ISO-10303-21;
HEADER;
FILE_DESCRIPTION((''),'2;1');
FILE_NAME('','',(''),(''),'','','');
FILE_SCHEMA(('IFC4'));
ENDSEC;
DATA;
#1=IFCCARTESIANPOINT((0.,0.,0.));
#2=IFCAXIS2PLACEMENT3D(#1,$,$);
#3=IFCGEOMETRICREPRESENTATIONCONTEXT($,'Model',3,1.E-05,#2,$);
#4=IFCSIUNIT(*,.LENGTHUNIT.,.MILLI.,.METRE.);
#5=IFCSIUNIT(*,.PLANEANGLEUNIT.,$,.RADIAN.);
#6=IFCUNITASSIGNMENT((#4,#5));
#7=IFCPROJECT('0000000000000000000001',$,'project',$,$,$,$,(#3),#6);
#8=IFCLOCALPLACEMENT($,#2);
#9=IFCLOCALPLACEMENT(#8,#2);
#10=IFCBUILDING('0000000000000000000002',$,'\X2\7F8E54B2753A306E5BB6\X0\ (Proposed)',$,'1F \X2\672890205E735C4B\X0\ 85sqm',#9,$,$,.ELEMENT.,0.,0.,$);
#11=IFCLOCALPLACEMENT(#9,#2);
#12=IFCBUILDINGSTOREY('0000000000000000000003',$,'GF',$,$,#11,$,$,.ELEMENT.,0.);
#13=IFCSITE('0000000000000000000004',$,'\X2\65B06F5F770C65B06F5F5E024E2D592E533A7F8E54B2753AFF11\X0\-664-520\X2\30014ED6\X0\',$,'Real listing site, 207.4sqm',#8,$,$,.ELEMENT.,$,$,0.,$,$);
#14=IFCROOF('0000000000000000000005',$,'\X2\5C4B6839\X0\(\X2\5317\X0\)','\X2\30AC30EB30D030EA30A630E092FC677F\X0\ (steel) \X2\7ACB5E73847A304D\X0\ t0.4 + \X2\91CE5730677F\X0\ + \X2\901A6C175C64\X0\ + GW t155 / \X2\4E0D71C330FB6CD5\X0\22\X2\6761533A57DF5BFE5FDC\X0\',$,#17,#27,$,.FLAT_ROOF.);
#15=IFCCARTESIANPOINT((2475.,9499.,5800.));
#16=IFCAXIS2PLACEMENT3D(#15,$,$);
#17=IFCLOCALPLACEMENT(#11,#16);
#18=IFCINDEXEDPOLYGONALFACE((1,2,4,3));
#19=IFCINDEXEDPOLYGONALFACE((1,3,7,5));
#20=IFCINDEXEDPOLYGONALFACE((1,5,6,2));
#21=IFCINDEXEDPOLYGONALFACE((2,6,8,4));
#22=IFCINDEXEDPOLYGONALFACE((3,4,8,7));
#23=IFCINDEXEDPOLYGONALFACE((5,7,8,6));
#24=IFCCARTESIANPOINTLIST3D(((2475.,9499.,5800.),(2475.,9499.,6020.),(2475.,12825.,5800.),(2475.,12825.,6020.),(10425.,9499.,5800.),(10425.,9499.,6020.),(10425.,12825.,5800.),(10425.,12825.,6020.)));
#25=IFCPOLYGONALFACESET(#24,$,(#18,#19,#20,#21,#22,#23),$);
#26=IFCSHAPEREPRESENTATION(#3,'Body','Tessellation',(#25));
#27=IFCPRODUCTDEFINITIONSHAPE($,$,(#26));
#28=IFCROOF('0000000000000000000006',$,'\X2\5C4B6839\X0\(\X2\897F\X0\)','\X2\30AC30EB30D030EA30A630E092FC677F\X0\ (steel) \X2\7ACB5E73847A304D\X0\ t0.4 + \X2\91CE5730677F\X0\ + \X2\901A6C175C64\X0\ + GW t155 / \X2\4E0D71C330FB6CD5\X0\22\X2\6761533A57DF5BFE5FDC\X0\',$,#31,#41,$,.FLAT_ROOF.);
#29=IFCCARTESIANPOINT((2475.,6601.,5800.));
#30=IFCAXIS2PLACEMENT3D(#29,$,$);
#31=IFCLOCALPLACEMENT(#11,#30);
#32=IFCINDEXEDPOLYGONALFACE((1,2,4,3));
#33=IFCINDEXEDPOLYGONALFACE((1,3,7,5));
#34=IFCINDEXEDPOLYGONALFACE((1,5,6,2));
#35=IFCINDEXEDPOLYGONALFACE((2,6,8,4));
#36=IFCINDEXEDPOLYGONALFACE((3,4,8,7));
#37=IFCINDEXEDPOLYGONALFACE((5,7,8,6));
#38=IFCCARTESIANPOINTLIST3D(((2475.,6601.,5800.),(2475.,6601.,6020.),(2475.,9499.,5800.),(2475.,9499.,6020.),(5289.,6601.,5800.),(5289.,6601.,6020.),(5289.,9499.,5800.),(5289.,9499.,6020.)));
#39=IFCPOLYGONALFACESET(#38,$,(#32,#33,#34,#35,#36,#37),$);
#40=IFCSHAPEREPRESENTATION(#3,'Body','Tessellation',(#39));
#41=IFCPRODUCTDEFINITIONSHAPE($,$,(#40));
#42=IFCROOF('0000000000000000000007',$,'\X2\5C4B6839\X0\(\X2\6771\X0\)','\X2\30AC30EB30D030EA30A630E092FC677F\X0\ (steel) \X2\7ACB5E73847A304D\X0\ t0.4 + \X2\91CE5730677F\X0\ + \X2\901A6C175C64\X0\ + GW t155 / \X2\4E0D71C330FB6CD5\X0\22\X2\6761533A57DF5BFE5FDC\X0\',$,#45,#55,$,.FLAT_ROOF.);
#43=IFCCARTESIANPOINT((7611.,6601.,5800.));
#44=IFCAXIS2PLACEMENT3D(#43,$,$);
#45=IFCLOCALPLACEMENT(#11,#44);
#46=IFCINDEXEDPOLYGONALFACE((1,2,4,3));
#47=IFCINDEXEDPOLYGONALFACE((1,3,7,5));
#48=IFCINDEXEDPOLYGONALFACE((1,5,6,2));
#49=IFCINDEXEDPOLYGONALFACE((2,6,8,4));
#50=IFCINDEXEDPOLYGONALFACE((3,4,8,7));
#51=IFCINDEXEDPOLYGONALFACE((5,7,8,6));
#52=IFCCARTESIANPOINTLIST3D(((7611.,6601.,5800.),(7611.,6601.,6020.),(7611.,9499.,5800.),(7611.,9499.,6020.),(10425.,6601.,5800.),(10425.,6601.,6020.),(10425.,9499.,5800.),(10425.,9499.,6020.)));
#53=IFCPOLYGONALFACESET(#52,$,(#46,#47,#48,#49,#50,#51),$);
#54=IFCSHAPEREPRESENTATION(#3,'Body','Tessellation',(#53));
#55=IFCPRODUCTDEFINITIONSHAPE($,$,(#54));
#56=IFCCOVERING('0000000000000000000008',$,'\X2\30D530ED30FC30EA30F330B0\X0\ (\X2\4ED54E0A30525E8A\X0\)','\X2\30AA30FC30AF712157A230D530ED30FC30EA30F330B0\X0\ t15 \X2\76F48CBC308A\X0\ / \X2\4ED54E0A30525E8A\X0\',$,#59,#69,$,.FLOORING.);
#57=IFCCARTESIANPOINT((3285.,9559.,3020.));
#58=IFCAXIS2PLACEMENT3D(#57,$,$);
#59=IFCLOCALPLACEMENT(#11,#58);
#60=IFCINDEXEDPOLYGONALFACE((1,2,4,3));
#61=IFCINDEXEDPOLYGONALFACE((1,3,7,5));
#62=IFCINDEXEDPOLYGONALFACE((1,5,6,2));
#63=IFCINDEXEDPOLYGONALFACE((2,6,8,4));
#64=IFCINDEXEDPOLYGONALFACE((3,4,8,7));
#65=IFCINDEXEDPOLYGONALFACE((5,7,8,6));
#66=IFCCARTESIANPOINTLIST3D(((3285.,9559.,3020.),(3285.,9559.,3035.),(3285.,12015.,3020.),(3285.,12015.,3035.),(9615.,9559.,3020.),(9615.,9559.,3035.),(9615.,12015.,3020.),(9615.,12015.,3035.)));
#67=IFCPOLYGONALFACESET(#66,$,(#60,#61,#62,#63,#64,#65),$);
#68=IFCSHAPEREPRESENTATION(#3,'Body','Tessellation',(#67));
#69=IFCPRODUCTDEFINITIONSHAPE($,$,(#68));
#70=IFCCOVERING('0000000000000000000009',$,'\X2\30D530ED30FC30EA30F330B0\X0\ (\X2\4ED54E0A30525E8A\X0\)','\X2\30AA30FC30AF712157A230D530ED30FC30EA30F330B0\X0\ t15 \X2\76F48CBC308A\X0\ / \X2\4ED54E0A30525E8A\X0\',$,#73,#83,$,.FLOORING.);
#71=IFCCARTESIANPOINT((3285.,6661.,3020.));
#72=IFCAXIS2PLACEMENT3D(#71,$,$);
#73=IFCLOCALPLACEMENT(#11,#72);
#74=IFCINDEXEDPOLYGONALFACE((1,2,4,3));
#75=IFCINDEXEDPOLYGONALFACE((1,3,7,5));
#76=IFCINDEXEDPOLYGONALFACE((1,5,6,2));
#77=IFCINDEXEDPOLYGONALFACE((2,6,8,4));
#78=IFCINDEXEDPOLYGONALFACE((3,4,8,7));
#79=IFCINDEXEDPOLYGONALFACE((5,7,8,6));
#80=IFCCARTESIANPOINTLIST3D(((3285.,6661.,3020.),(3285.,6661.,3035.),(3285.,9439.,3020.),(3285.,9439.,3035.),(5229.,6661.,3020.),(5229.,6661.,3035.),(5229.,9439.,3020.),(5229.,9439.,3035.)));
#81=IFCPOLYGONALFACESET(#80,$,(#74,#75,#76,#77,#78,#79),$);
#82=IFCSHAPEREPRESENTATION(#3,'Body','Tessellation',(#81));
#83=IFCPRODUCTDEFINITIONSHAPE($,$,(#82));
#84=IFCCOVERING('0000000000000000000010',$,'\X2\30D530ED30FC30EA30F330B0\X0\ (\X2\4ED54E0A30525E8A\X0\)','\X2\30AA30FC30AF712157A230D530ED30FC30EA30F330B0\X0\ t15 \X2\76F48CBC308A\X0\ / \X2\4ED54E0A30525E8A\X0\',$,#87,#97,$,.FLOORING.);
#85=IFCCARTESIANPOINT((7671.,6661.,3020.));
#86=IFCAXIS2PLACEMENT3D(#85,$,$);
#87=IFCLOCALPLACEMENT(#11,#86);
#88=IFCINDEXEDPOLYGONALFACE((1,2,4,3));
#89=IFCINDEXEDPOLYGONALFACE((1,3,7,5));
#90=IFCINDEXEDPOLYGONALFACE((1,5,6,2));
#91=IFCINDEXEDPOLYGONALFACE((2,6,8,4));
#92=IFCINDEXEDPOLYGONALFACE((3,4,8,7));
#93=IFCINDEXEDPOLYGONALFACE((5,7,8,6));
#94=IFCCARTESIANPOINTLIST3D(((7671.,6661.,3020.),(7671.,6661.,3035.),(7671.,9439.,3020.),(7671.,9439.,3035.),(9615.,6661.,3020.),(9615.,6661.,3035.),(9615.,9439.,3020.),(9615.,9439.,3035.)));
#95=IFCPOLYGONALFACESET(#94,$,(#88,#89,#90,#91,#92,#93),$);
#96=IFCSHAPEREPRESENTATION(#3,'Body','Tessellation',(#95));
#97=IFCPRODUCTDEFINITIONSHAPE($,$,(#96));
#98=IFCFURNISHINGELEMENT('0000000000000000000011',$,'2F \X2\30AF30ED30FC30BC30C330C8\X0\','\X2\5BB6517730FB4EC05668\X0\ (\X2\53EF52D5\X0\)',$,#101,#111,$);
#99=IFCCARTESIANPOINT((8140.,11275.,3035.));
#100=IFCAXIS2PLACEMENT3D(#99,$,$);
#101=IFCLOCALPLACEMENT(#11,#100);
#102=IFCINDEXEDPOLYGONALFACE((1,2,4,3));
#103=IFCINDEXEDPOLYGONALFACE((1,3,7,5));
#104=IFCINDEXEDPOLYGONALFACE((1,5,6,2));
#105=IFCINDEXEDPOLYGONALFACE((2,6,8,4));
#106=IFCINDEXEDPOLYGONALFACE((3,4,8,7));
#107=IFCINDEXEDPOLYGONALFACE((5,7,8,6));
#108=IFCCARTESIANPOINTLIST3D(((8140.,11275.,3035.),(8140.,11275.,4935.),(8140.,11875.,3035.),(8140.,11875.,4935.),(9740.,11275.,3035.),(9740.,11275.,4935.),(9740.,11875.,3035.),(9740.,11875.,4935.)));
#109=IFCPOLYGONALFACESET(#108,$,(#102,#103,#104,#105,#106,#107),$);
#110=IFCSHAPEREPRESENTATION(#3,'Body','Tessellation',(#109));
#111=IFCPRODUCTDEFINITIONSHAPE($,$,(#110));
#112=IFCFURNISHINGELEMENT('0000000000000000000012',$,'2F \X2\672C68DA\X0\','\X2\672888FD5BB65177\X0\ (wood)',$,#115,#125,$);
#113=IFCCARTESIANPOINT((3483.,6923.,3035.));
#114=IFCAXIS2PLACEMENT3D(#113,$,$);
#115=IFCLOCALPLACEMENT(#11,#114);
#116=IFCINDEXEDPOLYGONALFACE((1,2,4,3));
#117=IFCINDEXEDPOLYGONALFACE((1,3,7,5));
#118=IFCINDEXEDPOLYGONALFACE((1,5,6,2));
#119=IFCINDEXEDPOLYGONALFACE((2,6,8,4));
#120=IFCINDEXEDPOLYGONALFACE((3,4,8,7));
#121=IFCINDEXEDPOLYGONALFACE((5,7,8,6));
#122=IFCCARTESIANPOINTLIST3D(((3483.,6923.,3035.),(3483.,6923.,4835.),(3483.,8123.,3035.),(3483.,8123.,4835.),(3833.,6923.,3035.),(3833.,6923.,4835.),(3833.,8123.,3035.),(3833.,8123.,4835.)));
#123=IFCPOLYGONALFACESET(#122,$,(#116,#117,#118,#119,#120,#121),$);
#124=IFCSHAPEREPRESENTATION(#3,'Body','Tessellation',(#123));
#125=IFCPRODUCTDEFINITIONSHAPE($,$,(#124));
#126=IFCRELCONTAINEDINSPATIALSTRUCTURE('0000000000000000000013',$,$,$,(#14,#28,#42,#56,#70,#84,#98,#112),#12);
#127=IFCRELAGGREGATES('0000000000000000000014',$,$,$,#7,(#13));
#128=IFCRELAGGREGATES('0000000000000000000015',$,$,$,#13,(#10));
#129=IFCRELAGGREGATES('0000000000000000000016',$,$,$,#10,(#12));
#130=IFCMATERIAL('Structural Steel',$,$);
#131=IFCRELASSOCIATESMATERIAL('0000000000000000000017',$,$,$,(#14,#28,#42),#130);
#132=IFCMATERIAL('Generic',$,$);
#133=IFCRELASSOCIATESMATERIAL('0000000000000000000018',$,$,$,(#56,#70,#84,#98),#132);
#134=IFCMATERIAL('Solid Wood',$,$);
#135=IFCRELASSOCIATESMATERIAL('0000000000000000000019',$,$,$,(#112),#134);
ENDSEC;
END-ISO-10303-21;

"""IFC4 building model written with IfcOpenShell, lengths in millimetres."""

from ifc_helpers import new_model, si_unit, frame, frame_2d, origin, place, context, project, spatial, rectangle, extrude, material, element, save


model = new_model("IFC4")

# Units and contexts
model_context = context("Model", 3, precision=1e-05, world=origin())
ifc_project = project(units=[si_unit("LENGTHUNIT", "METRE", prefix="MILLI"), si_unit("PLANEANGLEUNIT", "RADIAN")], contexts=[model_context])

# Site, building, storey
site_placement = place(None, origin())
site = spatial("IfcSite", under=ifc_project, at=site_placement, Name="新潟県新潟市中央区美咲町１-664-520、他", ObjectType="Real listing site, 207.4sqm", CompositionType="ELEMENT", RefElevation=0.0)
building_placement = place(site_placement, origin())
building = spatial("IfcBuilding", under=site, at=building_placement, Name="美咲町の家 (Proposed)", ObjectType="1F 木造平屋 85sqm", CompositionType="ELEMENT", ElevationOfRefHeight=0.0, ElevationOfTerrain=0.0)
storey_placement = place(building_placement, origin())
storey = spatial("IfcBuildingStorey", under=building, at=storey_placement, Name="GF", CompositionType="ELEMENT", Elevation=0.0)

# Shared definitions
ifc_material_1 = material(Name="Solid Wood")

# Shared definitions
ifc_material_2 = material(Name="Generic")

# Roofs
ifc_material_3 = material(Name="Structural Steel")
for number, where, name in (
    (1, (2475.0, 9499.0, 5800.0), "屋根(北)"),
):
    element("IfcRoof", number, at=place(storey_placement, frame(where)), inside=storey, material=ifc_material_3, Name=name, Description="ガルバリウム鋼板 (steel) 立平葺き t0.4 + 野地板 + 通気層 + GW t155 / 不燃・法22条区域対応", PredefinedType="FLAT_ROOF", context=model_context, shape_type="SweptSolid", body=[
        extrude(rectangle(XDim=7950.0, YDim=3326.0, at=frame_2d((3975.0, 1663.0))), frame((2475.0, 9499.0, 5800.0)), (0.0, 0.0, 1.0), 220.0),
    ])
roof_1_placement = place(storey_placement, frame((2475.0, 6601.0, 5800.0)))
element("IfcRoof", 2, at=roof_1_placement, inside=storey, material=ifc_material_3, Name="屋根(西)", Description="ガルバリウム鋼板 (steel) 立平葺き t0.4 + 野地板 + 通気層 + GW t155 / 不燃・法22条区域対応", PredefinedType="FLAT_ROOF", context=model_context, shape_type="SweptSolid", body=[
    extrude(rectangle(XDim=2814.0, YDim=2898.0, at=frame_2d((1407.0, 1449.0))), frame((2475.0, 6601.0, 5800.0)), (0.0, 0.0, 1.0), 220.0),
])
roof_2_placement = place(storey_placement, frame((7611.0, 6601.0, 5800.0)))
element("IfcRoof", 3, at=roof_2_placement, inside=storey, material=ifc_material_3, Name="屋根(東)", Description="ガルバリウム鋼板 (steel) 立平葺き t0.4 + 野地板 + 通気層 + GW t155 / 不燃・法22条区域対応", PredefinedType="FLAT_ROOF", context=model_context, shape_type="SweptSolid", body=[
    extrude(rectangle(XDim=2814.0, YDim=2898.0, at=frame_2d((1407.0, 1449.0))), frame((7611.0, 6601.0, 5800.0)), (0.0, 0.0, 1.0), 220.0),
])

# Coverings
covering_1_placement = place(storey_placement, frame((3285.0, 9559.0, 3020.0)))
element("IfcCovering", 4, at=covering_1_placement, inside=storey, material=ifc_material_2, Name="フローリング (仕上げ床)", Description="オーク無垢フローリング t15 直貼り / 仕上げ床", PredefinedType="FLOORING", context=model_context, shape_type="SweptSolid", body=[
    extrude(rectangle(XDim=6330.0, YDim=2456.0, at=frame_2d((3165.0, 1228.0))), frame((3285.0, 9559.0, 3020.0)), (0.0, 0.0, 1.0), 15.0),
])
covering_2_placement = place(storey_placement, frame((3285.0, 6661.0, 3020.0)))
element("IfcCovering", 5, at=covering_2_placement, inside=storey, material=ifc_material_2, Name="フローリング (仕上げ床)", Description="オーク無垢フローリング t15 直貼り / 仕上げ床", PredefinedType="FLOORING", context=model_context, shape_type="SweptSolid", body=[
    extrude(rectangle(XDim=1944.0, YDim=2778.0, at=frame_2d((972.0, 1389.0))), frame((3285.0, 6661.0, 3020.0)), (0.0, 0.0, 1.0), 15.0),
])
covering_3_placement = place(storey_placement, frame((7671.0, 6661.0, 3020.0)))
element("IfcCovering", 6, at=covering_3_placement, inside=storey, material=ifc_material_2, Name="フローリング (仕上げ床)", Description="オーク無垢フローリング t15 直貼り / 仕上げ床", PredefinedType="FLOORING", context=model_context, shape_type="SweptSolid", body=[
    extrude(rectangle(XDim=1944.0, YDim=2778.0, at=frame_2d((972.0, 1389.0))), frame((7671.0, 6661.0, 3020.0)), (0.0, 0.0, 1.0), 15.0),
])

# Furnishing elements
furnishing_1_placement = place(storey_placement, frame((8140.0, 11275.0, 3035.0)))
element("IfcFurnishingElement", 7, at=furnishing_1_placement, inside=storey, material=ifc_material_2, Name="2F クローゼット", Description="家具・什器 (可動)", context=model_context, shape_type="SweptSolid", body=[
    extrude(rectangle(XDim=1600.0, YDim=600.0, at=frame_2d((800.0, 300.0))), frame((8140.0, 11275.0, 3035.0)), (0.0, 0.0, 1.0), 1900.0),
])
furnishing_2_placement = place(storey_placement, frame((3483.0, 6923.0, 3035.0)))
element("IfcFurnishingElement", 8, at=furnishing_2_placement, inside=storey, material=ifc_material_1, Name="2F 本棚", Description="木製家具 (wood)", context=model_context, shape_type="SweptSolid", body=[
    extrude(rectangle(XDim=350.0, YDim=1200.0, at=frame_2d((175.0, 600.0))), frame((3483.0, 6923.0, 3035.0)), (0.0, 0.0, 1.0), 1800.0),
])

save(model, "model.ifc")
